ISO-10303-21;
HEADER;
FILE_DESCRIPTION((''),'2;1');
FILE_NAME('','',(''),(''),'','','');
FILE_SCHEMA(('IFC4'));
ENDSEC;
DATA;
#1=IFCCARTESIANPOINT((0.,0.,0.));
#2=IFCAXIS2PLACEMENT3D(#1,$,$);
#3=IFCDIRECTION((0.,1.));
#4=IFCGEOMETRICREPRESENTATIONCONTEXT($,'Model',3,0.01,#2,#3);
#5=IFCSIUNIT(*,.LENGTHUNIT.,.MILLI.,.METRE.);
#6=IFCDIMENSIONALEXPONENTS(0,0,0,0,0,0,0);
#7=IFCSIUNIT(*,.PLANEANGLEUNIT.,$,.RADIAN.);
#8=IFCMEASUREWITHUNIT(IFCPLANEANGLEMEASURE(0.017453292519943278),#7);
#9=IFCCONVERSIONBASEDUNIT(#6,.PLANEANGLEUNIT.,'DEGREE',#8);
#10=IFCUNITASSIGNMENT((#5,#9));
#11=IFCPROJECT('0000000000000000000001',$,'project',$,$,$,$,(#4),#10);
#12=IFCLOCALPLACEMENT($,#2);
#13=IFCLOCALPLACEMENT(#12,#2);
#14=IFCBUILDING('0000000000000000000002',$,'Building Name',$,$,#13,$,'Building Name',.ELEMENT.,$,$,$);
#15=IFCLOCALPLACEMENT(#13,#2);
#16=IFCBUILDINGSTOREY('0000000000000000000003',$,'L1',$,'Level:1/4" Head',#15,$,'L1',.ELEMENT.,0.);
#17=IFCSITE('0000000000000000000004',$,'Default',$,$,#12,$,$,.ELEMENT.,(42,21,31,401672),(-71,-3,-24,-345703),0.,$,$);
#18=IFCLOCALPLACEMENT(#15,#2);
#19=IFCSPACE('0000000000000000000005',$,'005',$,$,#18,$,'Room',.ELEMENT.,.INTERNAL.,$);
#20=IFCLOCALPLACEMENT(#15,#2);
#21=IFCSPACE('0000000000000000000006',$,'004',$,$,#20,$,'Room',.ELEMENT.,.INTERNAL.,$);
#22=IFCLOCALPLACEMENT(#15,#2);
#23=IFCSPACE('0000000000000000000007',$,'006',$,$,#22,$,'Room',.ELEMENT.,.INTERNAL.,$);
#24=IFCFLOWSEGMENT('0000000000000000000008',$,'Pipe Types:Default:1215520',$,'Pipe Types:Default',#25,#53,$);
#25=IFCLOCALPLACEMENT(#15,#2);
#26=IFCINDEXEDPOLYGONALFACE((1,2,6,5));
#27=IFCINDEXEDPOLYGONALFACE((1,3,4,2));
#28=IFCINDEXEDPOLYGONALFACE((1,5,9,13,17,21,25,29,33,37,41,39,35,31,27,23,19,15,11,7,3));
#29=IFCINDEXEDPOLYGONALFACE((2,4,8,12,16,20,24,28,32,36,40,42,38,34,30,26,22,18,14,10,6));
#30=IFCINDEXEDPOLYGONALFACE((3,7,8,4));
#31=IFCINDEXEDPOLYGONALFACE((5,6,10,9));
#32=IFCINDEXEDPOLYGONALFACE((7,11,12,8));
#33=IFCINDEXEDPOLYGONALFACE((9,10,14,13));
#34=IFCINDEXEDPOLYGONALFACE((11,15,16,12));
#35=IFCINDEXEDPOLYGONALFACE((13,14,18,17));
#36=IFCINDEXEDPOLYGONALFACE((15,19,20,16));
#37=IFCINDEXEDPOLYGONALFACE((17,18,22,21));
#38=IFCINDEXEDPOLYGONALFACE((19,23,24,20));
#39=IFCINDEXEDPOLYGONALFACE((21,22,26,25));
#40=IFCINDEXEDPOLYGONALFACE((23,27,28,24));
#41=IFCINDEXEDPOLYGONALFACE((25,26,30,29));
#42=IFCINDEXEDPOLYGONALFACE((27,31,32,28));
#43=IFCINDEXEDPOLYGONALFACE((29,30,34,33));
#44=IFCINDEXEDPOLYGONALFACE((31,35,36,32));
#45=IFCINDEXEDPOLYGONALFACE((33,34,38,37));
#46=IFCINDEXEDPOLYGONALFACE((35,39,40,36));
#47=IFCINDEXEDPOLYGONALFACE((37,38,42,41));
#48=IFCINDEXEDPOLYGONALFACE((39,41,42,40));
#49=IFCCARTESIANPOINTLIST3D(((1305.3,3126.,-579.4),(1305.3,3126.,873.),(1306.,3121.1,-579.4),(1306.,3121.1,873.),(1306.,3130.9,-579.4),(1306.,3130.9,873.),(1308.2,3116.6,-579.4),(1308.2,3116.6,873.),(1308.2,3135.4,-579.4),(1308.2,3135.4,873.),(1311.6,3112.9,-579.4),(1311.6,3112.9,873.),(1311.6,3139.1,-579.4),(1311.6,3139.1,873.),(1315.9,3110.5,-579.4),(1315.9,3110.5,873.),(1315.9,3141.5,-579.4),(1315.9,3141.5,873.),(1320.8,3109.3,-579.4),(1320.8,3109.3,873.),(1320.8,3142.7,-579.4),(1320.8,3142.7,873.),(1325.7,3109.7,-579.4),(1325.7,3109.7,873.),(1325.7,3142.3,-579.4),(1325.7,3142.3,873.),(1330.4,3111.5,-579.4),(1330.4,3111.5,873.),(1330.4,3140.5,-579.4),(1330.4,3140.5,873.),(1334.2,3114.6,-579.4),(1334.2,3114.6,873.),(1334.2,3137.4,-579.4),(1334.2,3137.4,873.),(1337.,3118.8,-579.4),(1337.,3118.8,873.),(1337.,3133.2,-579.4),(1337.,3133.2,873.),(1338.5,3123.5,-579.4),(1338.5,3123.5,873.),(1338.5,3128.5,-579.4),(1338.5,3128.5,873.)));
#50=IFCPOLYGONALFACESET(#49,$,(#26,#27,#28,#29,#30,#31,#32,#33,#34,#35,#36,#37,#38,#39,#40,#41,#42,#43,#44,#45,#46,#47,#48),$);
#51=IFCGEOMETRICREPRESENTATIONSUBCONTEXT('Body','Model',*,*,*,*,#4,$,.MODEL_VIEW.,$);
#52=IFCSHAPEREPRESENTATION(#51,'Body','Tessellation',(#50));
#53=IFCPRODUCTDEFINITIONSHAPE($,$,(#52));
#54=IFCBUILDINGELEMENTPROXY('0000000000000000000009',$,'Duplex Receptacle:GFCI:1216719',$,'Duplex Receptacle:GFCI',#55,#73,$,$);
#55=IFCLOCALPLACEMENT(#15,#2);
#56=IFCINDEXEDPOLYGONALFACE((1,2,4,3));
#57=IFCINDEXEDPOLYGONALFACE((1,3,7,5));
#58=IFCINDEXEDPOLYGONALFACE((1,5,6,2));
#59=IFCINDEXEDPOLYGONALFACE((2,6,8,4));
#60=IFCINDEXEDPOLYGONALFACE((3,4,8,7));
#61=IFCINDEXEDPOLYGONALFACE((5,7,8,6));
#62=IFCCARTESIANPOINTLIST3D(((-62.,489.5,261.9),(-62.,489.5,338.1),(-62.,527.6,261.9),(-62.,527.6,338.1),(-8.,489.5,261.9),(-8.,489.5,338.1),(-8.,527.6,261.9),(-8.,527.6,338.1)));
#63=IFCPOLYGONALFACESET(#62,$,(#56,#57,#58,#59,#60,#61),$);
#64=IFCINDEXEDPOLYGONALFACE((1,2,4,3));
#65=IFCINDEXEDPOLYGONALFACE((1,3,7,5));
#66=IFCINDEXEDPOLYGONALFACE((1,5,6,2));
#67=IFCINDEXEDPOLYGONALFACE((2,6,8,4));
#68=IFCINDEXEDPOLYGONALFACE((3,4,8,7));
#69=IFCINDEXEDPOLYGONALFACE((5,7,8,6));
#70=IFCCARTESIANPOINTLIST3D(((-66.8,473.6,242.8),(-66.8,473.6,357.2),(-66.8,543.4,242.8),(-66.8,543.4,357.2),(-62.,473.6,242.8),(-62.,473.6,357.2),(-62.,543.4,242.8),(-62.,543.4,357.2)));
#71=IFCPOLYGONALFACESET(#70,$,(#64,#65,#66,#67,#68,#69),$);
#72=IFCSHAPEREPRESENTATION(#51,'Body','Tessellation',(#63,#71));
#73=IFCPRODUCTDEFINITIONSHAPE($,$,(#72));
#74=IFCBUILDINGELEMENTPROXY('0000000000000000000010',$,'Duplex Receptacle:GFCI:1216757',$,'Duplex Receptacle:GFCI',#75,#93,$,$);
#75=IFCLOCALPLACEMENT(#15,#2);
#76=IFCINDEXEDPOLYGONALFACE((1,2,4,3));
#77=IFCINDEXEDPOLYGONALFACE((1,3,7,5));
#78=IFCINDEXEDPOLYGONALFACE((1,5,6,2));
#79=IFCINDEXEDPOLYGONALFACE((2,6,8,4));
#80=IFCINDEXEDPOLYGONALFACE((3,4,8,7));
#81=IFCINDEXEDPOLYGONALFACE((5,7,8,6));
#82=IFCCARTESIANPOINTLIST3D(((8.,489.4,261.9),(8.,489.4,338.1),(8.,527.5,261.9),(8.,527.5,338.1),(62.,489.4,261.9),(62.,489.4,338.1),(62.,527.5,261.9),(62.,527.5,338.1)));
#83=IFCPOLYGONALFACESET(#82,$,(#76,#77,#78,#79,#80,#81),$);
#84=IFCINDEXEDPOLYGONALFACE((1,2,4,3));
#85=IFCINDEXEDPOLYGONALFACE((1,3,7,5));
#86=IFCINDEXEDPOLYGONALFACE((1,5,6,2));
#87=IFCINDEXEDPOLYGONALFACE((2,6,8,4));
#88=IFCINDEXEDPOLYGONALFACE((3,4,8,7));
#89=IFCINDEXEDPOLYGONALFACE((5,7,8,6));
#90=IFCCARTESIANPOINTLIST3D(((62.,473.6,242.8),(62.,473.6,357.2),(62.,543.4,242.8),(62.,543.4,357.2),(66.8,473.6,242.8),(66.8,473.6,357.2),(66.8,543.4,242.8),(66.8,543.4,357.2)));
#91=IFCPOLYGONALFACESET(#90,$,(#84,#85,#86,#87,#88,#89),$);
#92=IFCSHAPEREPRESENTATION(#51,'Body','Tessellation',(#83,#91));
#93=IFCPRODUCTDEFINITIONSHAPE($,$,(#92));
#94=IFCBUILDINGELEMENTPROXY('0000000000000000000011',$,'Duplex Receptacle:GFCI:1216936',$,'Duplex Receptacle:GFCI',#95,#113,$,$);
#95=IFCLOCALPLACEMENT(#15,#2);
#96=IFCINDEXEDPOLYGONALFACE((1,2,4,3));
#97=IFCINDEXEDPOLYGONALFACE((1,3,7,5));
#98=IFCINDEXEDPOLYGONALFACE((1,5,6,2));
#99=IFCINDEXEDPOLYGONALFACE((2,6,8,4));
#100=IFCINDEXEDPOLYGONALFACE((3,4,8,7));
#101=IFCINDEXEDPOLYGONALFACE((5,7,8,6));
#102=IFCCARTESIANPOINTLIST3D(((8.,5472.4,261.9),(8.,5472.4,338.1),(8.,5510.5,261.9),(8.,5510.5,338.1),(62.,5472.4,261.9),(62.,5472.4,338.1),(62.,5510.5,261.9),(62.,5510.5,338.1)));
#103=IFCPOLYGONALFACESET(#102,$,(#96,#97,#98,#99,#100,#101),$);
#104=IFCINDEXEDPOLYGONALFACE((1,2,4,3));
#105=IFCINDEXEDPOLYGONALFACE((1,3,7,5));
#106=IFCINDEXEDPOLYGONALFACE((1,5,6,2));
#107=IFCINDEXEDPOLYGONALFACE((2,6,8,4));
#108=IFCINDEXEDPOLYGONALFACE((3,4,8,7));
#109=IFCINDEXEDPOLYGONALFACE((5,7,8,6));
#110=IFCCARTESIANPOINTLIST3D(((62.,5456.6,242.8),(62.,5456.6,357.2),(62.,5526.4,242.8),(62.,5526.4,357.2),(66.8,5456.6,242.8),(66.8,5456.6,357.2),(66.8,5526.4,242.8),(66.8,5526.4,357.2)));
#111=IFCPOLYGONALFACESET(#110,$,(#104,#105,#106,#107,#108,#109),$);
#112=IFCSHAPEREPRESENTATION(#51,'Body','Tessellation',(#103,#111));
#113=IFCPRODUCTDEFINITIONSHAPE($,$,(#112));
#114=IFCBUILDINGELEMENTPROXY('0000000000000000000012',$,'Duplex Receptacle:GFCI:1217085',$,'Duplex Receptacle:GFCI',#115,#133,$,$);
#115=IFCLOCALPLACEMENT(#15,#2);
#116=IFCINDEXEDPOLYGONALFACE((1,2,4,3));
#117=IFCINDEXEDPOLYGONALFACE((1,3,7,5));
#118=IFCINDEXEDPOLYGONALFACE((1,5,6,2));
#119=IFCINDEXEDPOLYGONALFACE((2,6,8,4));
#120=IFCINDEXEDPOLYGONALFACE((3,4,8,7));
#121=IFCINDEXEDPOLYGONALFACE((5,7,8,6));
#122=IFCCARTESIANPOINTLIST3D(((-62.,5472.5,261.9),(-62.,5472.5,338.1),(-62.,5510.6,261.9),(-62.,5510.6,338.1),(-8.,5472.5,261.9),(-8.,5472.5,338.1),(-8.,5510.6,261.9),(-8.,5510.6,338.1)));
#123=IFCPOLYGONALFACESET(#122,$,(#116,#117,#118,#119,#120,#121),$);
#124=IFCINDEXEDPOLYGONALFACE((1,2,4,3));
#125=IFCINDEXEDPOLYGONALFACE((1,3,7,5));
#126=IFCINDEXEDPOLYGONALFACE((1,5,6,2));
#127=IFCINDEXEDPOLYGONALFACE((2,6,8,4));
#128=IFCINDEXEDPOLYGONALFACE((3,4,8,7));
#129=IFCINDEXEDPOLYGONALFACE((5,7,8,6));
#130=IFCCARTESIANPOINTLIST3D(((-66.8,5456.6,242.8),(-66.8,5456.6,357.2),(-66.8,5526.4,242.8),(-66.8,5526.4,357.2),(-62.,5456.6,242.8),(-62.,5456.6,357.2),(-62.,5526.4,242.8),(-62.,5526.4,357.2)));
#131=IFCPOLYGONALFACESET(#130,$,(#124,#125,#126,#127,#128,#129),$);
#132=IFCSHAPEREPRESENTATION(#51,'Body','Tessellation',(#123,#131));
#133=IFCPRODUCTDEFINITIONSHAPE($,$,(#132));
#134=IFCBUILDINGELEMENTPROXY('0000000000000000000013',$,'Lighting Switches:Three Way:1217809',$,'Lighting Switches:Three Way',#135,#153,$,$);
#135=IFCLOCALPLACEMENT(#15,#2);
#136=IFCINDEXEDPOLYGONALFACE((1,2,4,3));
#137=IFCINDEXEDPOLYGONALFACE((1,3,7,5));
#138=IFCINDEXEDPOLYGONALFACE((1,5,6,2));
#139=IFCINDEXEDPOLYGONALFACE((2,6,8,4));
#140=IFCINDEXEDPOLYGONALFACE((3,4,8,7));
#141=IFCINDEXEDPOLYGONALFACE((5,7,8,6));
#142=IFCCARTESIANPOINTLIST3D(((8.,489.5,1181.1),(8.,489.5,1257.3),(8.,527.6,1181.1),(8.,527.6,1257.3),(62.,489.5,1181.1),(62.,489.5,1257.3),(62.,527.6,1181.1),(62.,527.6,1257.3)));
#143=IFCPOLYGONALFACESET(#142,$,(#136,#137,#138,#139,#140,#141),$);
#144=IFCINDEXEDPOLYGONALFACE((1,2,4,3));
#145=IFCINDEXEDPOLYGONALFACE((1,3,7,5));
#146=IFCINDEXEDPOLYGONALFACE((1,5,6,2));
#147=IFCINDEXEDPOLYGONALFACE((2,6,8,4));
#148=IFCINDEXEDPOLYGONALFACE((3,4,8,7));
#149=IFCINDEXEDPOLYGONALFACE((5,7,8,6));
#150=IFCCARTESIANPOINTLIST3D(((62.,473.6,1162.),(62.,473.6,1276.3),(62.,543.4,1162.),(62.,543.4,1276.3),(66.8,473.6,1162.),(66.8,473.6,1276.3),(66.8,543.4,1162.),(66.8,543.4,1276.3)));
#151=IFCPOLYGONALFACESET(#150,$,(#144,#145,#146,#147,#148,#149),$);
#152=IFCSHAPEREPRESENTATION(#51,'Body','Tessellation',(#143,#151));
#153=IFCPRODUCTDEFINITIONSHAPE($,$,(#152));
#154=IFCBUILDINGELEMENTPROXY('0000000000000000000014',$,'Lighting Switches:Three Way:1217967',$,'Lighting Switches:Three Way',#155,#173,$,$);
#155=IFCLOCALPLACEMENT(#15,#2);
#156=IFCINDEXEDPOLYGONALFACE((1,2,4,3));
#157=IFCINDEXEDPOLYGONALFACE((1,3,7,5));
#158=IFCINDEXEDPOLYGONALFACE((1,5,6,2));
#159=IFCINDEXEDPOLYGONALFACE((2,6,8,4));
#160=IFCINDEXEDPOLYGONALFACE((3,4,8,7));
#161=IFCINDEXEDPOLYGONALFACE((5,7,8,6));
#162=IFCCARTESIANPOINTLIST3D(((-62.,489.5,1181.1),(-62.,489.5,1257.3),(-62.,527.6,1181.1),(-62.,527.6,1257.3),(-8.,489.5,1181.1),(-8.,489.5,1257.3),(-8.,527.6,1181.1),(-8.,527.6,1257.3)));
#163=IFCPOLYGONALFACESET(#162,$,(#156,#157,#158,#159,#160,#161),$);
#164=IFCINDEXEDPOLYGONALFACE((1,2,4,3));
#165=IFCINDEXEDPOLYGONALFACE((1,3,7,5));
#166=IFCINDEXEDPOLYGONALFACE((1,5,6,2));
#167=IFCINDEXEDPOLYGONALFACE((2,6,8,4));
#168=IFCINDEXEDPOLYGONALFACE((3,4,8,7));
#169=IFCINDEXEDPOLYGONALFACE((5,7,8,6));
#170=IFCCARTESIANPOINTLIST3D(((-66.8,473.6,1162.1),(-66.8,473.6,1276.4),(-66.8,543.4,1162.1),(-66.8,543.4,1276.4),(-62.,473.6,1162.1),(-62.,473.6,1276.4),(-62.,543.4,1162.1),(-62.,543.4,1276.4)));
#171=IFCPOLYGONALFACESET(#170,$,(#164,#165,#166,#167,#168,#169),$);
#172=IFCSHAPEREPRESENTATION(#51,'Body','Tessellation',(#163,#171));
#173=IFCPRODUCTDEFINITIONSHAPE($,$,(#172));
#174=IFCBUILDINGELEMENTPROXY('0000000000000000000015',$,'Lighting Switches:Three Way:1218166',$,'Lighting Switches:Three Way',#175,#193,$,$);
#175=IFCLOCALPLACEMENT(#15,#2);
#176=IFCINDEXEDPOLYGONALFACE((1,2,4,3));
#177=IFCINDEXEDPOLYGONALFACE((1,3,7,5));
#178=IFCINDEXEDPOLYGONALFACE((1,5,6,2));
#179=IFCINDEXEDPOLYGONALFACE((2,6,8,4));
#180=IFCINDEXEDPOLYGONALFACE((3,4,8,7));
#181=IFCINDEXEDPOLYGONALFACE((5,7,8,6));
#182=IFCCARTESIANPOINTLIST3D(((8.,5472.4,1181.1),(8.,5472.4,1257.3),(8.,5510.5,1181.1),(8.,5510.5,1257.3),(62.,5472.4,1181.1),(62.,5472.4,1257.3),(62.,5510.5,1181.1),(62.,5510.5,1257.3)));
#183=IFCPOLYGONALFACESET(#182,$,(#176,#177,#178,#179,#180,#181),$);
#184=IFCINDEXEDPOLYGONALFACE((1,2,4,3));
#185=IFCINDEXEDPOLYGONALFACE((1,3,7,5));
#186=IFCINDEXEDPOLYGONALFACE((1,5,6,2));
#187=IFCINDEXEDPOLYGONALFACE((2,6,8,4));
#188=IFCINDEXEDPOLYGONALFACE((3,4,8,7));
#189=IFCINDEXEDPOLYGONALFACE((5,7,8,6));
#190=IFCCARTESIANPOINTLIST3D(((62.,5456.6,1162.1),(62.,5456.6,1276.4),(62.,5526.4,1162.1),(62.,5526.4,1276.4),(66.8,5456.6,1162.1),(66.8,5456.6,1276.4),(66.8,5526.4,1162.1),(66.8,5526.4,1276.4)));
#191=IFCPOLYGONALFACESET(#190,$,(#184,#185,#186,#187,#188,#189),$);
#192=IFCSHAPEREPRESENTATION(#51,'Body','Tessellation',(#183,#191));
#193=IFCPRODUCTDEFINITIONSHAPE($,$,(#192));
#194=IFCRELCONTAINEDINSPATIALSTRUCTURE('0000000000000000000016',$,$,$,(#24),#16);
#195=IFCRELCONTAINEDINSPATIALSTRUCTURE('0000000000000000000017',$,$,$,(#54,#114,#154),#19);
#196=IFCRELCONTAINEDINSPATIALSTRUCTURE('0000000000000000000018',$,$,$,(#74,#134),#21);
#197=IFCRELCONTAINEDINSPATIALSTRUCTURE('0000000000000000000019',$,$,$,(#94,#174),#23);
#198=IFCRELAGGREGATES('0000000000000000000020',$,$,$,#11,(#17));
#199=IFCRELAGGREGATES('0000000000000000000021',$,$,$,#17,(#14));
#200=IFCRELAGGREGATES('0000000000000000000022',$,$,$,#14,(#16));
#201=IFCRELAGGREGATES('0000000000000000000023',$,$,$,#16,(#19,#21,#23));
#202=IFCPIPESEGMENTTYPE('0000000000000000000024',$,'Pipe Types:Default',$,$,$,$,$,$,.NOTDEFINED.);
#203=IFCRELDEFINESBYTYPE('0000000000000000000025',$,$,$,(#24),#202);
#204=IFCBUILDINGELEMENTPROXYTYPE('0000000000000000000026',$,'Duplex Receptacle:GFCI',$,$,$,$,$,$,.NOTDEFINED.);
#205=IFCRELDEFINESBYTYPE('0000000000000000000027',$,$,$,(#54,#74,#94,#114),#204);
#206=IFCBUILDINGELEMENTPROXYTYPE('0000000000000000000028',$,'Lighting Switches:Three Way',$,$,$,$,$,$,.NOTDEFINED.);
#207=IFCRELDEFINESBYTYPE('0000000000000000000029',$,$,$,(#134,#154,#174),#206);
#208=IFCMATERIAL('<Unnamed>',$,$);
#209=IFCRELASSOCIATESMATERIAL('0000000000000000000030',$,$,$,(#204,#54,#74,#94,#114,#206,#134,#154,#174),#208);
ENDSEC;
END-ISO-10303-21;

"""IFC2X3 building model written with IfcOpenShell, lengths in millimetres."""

from ifc_helpers import new_model, entity, si_unit, converted_unit, direction, frame, frame_2d, origin, origin_2d_with_axis, place, context, subcontext, project, spatial, rectangle, circle, extrude, source, transform, mapped, material, type_object, type_shapes, element, save


model = new_model("IFC2X3")

# Units and contexts
model_context = context("Model", 3, precision=0.01, world=origin(), true_north=direction((0.0, 1.0)))
body_context = subcontext(model_context, "Body", "Model", "MODEL_VIEW")
ifc_project = project(units=[si_unit("LENGTHUNIT", "METRE", prefix="MILLI"), converted_unit("PLANEANGLEUNIT", "DEGREE", entity("IfcPlaneAngleMeasure", 0.017453292519943278), si_unit("PLANEANGLEUNIT", "RADIAN"), dimensions=[0, 0, 0, 0, 0, 0, 0])], contexts=[model_context])

# Site, building, storey
site_placement = place(None, origin())
site = spatial("IfcSite", under=ifc_project, at=site_placement, Name="Default", CompositionType="ELEMENT", RefLatitude=(42, 21, 31, 401672), RefLongitude=(-71, -3, -24, -345703), RefElevation=0.0)
building_placement = place(site_placement, origin())
building = spatial("IfcBuilding", under=site, at=building_placement, Name="Building Name", LongName="Building Name", CompositionType="ELEMENT")
storey_placement = place(building_placement, origin())
storey = spatial("IfcBuildingStorey", under=building, at=storey_placement, Name="L1", ObjectType="Level:1/4\" Head", LongName="L1", CompositionType="ELEMENT", Elevation=0.0)

# Flow segment
pipe_segment_type = type_object("IfcPipeSegmentType", Name="Pipe Types:Default", PredefinedType="NOTDEFINED")
flow_segment_1_placement = place(storey_placement, origin())
element("IfcFlowSegment", 1, at=flow_segment_1_placement, inside=storey, type_object=pipe_segment_type, Name="Pipe Types:Default:1215520", ObjectType="Pipe Types:Default", context=body_context, shape_type="SweptSolid", body=[
    extrude(circle(Radius=16.7, at=origin_2d_with_axis()), frame((1322.0, 3126.0, -579.4), z_axis=(0.0, 0.0, 1.0), x_axis=(-1.0, 0.0, 0.0)), (0.0, 0.0, 1.0), 1452.4),
])

# Shared definitions
space_1_placement = place(storey_placement, origin())
space_1 = spatial("IfcSpace", under=storey, at=space_1_placement, Name="005", LongName="Room", CompositionType="ELEMENT", InteriorOrExteriorSpace="INTERNAL")

# Building element proxy
ifc_material_1 = material(Name="<Unnamed>")
building_element_proxy_type_1 = type_object("IfcBuildingElementProxyType", Name="Duplex Receptacle:GFCI", PredefinedType="NOTDEFINED", material=ifc_material_1)
shared_shape_1 = source(origin(), body_context, "Body", "SweptSolid", [
    extrude(rectangle(XDim=38.1, YDim=76.2, at=origin_2d_with_axis()), frame((0.0, 0.0, -54.0), z_axis=(0.0, 0.0, 1.0), x_axis=(-1.0, 0.0, 0.0)), (0.0, 0.0, 1.0), 54.0),
    extrude(rectangle(XDim=69.8, YDim=114.3, at=frame_2d((0.0, 0.0), x_axis=(1.0, 0.0))), frame((0.0, 0.0, 0.0), z_axis=(0.0, 0.0, 1.0), x_axis=(-1.0, 0.0, 0.0)), (0.0, 0.0, 1.0), 4.8),
])
type_shapes(building_element_proxy_type_1, [shared_shape_1])
proxy_1_placement = place(space_1_placement, frame((-62.0, 508.5, 300.0), z_axis=(-1.0, 0.0, 0.0), x_axis=(0.0, -1.0, 0.0)))
element("IfcBuildingElementProxy", 2, at=proxy_1_placement, inside=space_1, type_object=building_element_proxy_type_1, material=ifc_material_1, Name="Duplex Receptacle:GFCI:1216719", ObjectType="Duplex Receptacle:GFCI", context=body_context, shape_type="MappedRepresentation", body=[
    mapped(shared_shape_1, transform((0.0, 0.0, 0.0), scale=1.0)),
])

# Shared definitions
space_2_placement = place(storey_placement, origin())
space_2 = spatial("IfcSpace", under=storey, at=space_2_placement, Name="004", LongName="Room", CompositionType="ELEMENT", InteriorOrExteriorSpace="INTERNAL")

# Building element proxy
proxy_2_placement = place(space_2_placement, frame((62.0, 508.5, 300.0), z_axis=(1.0, 0.0, 0.0), x_axis=(0.0, 1.0, 0.0)))
element("IfcBuildingElementProxy", 3, at=proxy_2_placement, inside=space_2, type_object=building_element_proxy_type_1, material=ifc_material_1, Name="Duplex Receptacle:GFCI:1216757", ObjectType="Duplex Receptacle:GFCI", context=body_context, shape_type="MappedRepresentation", body=[
    mapped(shared_shape_1, transform((0.0, 0.0, 0.0), scale=1.0)),
])

# Shared definitions
space_3_placement = place(storey_placement, origin())
space_3 = spatial("IfcSpace", under=storey, at=space_3_placement, Name="006", LongName="Room", CompositionType="ELEMENT", InteriorOrExteriorSpace="INTERNAL")

# Building element proxies
proxy_3_placement = place(space_3_placement, frame((62.0, 5491.5, 300.0), z_axis=(1.0, 0.0, 0.0), x_axis=(0.0, 1.0, 0.0)))
element("IfcBuildingElementProxy", 4, at=proxy_3_placement, inside=space_3, type_object=building_element_proxy_type_1, material=ifc_material_1, Name="Duplex Receptacle:GFCI:1216936", ObjectType="Duplex Receptacle:GFCI", context=body_context, shape_type="MappedRepresentation", body=[
    mapped(shared_shape_1, transform((0.0, 0.0, 0.0), scale=1.0)),
])
proxy_4_placement = place(space_1_placement, frame((-62.0, 5491.5, 300.0), z_axis=(-1.0, 0.0, 0.0), x_axis=(0.0, -1.0, 0.0)))
element("IfcBuildingElementProxy", 5, at=proxy_4_placement, inside=space_1, type_object=building_element_proxy_type_1, material=ifc_material_1, Name="Duplex Receptacle:GFCI:1217085", ObjectType="Duplex Receptacle:GFCI", context=body_context, shape_type="MappedRepresentation", body=[
    mapped(shared_shape_1, transform((0.0, 0.0, 0.0), scale=1.0)),
])
building_element_proxy_type_2 = type_object("IfcBuildingElementProxyType", Name="Lighting Switches:Three Way", PredefinedType="NOTDEFINED", material=ifc_material_1)
shared_shape_2 = source(origin(), body_context, "Body", "SweptSolid", [
    extrude(rectangle(XDim=38.1, YDim=76.2, at=origin_2d_with_axis()), frame((0.0, 0.0, -54.0), z_axis=(0.0, 0.0, 1.0), x_axis=(-1.0, 0.0, 0.0)), (0.0, 0.0, 1.0), 54.0),
    extrude(rectangle(XDim=69.8, YDim=114.3, at=frame_2d((0.0, 0.0), x_axis=(1.0, 0.0))), frame((0.0, 0.0, 0.0), z_axis=(0.0, 0.0, 1.0), x_axis=(-1.0, 0.0, 0.0)), (0.0, 0.0, 1.0), 4.8),
])
type_shapes(building_element_proxy_type_2, [shared_shape_2])
proxy_5_placement = place(space_2_placement, frame((62.0, 508.5, 1219.2), z_axis=(1.0, 0.0, 0.0), x_axis=(0.0, -1.0, 0.0)))
element("IfcBuildingElementProxy", 6, at=proxy_5_placement, inside=space_2, type_object=building_element_proxy_type_2, material=ifc_material_1, Name="Lighting Switches:Three Way:1217809", ObjectType="Lighting Switches:Three Way", context=body_context, shape_type="MappedRepresentation", body=[
    mapped(shared_shape_2, transform((0.0, 0.0, 0.0), scale=1.0)),
])
proxy_6_placement = place(space_1_placement, frame((-62.0, 508.5, 1219.2), z_axis=(-1.0, 0.0, 0.0), x_axis=(0.0, -1.0, 0.0)))
element("IfcBuildingElementProxy", 7, at=proxy_6_placement, inside=space_1, type_object=building_element_proxy_type_2, material=ifc_material_1, Name="Lighting Switches:Three Way:1217967", ObjectType="Lighting Switches:Three Way", context=body_context, shape_type="MappedRepresentation", body=[
    mapped(shared_shape_2, transform((0.0, 0.0, 0.0), scale=1.0)),
])
proxy_7_placement = place(space_3_placement, frame((62.0, 5491.5, 1219.2), z_axis=(1.0, 0.0, 0.0), x_axis=(0.0, 1.0, 0.0)))
element("IfcBuildingElementProxy", 8, at=proxy_7_placement, inside=space_3, type_object=building_element_proxy_type_2, material=ifc_material_1, Name="Lighting Switches:Three Way:1218166", ObjectType="Lighting Switches:Three Way", context=body_context, shape_type="MappedRepresentation", body=[
    mapped(shared_shape_2, transform((0.0, 0.0, 0.0), scale=1.0)),
])

save(model, "model.ifc")
